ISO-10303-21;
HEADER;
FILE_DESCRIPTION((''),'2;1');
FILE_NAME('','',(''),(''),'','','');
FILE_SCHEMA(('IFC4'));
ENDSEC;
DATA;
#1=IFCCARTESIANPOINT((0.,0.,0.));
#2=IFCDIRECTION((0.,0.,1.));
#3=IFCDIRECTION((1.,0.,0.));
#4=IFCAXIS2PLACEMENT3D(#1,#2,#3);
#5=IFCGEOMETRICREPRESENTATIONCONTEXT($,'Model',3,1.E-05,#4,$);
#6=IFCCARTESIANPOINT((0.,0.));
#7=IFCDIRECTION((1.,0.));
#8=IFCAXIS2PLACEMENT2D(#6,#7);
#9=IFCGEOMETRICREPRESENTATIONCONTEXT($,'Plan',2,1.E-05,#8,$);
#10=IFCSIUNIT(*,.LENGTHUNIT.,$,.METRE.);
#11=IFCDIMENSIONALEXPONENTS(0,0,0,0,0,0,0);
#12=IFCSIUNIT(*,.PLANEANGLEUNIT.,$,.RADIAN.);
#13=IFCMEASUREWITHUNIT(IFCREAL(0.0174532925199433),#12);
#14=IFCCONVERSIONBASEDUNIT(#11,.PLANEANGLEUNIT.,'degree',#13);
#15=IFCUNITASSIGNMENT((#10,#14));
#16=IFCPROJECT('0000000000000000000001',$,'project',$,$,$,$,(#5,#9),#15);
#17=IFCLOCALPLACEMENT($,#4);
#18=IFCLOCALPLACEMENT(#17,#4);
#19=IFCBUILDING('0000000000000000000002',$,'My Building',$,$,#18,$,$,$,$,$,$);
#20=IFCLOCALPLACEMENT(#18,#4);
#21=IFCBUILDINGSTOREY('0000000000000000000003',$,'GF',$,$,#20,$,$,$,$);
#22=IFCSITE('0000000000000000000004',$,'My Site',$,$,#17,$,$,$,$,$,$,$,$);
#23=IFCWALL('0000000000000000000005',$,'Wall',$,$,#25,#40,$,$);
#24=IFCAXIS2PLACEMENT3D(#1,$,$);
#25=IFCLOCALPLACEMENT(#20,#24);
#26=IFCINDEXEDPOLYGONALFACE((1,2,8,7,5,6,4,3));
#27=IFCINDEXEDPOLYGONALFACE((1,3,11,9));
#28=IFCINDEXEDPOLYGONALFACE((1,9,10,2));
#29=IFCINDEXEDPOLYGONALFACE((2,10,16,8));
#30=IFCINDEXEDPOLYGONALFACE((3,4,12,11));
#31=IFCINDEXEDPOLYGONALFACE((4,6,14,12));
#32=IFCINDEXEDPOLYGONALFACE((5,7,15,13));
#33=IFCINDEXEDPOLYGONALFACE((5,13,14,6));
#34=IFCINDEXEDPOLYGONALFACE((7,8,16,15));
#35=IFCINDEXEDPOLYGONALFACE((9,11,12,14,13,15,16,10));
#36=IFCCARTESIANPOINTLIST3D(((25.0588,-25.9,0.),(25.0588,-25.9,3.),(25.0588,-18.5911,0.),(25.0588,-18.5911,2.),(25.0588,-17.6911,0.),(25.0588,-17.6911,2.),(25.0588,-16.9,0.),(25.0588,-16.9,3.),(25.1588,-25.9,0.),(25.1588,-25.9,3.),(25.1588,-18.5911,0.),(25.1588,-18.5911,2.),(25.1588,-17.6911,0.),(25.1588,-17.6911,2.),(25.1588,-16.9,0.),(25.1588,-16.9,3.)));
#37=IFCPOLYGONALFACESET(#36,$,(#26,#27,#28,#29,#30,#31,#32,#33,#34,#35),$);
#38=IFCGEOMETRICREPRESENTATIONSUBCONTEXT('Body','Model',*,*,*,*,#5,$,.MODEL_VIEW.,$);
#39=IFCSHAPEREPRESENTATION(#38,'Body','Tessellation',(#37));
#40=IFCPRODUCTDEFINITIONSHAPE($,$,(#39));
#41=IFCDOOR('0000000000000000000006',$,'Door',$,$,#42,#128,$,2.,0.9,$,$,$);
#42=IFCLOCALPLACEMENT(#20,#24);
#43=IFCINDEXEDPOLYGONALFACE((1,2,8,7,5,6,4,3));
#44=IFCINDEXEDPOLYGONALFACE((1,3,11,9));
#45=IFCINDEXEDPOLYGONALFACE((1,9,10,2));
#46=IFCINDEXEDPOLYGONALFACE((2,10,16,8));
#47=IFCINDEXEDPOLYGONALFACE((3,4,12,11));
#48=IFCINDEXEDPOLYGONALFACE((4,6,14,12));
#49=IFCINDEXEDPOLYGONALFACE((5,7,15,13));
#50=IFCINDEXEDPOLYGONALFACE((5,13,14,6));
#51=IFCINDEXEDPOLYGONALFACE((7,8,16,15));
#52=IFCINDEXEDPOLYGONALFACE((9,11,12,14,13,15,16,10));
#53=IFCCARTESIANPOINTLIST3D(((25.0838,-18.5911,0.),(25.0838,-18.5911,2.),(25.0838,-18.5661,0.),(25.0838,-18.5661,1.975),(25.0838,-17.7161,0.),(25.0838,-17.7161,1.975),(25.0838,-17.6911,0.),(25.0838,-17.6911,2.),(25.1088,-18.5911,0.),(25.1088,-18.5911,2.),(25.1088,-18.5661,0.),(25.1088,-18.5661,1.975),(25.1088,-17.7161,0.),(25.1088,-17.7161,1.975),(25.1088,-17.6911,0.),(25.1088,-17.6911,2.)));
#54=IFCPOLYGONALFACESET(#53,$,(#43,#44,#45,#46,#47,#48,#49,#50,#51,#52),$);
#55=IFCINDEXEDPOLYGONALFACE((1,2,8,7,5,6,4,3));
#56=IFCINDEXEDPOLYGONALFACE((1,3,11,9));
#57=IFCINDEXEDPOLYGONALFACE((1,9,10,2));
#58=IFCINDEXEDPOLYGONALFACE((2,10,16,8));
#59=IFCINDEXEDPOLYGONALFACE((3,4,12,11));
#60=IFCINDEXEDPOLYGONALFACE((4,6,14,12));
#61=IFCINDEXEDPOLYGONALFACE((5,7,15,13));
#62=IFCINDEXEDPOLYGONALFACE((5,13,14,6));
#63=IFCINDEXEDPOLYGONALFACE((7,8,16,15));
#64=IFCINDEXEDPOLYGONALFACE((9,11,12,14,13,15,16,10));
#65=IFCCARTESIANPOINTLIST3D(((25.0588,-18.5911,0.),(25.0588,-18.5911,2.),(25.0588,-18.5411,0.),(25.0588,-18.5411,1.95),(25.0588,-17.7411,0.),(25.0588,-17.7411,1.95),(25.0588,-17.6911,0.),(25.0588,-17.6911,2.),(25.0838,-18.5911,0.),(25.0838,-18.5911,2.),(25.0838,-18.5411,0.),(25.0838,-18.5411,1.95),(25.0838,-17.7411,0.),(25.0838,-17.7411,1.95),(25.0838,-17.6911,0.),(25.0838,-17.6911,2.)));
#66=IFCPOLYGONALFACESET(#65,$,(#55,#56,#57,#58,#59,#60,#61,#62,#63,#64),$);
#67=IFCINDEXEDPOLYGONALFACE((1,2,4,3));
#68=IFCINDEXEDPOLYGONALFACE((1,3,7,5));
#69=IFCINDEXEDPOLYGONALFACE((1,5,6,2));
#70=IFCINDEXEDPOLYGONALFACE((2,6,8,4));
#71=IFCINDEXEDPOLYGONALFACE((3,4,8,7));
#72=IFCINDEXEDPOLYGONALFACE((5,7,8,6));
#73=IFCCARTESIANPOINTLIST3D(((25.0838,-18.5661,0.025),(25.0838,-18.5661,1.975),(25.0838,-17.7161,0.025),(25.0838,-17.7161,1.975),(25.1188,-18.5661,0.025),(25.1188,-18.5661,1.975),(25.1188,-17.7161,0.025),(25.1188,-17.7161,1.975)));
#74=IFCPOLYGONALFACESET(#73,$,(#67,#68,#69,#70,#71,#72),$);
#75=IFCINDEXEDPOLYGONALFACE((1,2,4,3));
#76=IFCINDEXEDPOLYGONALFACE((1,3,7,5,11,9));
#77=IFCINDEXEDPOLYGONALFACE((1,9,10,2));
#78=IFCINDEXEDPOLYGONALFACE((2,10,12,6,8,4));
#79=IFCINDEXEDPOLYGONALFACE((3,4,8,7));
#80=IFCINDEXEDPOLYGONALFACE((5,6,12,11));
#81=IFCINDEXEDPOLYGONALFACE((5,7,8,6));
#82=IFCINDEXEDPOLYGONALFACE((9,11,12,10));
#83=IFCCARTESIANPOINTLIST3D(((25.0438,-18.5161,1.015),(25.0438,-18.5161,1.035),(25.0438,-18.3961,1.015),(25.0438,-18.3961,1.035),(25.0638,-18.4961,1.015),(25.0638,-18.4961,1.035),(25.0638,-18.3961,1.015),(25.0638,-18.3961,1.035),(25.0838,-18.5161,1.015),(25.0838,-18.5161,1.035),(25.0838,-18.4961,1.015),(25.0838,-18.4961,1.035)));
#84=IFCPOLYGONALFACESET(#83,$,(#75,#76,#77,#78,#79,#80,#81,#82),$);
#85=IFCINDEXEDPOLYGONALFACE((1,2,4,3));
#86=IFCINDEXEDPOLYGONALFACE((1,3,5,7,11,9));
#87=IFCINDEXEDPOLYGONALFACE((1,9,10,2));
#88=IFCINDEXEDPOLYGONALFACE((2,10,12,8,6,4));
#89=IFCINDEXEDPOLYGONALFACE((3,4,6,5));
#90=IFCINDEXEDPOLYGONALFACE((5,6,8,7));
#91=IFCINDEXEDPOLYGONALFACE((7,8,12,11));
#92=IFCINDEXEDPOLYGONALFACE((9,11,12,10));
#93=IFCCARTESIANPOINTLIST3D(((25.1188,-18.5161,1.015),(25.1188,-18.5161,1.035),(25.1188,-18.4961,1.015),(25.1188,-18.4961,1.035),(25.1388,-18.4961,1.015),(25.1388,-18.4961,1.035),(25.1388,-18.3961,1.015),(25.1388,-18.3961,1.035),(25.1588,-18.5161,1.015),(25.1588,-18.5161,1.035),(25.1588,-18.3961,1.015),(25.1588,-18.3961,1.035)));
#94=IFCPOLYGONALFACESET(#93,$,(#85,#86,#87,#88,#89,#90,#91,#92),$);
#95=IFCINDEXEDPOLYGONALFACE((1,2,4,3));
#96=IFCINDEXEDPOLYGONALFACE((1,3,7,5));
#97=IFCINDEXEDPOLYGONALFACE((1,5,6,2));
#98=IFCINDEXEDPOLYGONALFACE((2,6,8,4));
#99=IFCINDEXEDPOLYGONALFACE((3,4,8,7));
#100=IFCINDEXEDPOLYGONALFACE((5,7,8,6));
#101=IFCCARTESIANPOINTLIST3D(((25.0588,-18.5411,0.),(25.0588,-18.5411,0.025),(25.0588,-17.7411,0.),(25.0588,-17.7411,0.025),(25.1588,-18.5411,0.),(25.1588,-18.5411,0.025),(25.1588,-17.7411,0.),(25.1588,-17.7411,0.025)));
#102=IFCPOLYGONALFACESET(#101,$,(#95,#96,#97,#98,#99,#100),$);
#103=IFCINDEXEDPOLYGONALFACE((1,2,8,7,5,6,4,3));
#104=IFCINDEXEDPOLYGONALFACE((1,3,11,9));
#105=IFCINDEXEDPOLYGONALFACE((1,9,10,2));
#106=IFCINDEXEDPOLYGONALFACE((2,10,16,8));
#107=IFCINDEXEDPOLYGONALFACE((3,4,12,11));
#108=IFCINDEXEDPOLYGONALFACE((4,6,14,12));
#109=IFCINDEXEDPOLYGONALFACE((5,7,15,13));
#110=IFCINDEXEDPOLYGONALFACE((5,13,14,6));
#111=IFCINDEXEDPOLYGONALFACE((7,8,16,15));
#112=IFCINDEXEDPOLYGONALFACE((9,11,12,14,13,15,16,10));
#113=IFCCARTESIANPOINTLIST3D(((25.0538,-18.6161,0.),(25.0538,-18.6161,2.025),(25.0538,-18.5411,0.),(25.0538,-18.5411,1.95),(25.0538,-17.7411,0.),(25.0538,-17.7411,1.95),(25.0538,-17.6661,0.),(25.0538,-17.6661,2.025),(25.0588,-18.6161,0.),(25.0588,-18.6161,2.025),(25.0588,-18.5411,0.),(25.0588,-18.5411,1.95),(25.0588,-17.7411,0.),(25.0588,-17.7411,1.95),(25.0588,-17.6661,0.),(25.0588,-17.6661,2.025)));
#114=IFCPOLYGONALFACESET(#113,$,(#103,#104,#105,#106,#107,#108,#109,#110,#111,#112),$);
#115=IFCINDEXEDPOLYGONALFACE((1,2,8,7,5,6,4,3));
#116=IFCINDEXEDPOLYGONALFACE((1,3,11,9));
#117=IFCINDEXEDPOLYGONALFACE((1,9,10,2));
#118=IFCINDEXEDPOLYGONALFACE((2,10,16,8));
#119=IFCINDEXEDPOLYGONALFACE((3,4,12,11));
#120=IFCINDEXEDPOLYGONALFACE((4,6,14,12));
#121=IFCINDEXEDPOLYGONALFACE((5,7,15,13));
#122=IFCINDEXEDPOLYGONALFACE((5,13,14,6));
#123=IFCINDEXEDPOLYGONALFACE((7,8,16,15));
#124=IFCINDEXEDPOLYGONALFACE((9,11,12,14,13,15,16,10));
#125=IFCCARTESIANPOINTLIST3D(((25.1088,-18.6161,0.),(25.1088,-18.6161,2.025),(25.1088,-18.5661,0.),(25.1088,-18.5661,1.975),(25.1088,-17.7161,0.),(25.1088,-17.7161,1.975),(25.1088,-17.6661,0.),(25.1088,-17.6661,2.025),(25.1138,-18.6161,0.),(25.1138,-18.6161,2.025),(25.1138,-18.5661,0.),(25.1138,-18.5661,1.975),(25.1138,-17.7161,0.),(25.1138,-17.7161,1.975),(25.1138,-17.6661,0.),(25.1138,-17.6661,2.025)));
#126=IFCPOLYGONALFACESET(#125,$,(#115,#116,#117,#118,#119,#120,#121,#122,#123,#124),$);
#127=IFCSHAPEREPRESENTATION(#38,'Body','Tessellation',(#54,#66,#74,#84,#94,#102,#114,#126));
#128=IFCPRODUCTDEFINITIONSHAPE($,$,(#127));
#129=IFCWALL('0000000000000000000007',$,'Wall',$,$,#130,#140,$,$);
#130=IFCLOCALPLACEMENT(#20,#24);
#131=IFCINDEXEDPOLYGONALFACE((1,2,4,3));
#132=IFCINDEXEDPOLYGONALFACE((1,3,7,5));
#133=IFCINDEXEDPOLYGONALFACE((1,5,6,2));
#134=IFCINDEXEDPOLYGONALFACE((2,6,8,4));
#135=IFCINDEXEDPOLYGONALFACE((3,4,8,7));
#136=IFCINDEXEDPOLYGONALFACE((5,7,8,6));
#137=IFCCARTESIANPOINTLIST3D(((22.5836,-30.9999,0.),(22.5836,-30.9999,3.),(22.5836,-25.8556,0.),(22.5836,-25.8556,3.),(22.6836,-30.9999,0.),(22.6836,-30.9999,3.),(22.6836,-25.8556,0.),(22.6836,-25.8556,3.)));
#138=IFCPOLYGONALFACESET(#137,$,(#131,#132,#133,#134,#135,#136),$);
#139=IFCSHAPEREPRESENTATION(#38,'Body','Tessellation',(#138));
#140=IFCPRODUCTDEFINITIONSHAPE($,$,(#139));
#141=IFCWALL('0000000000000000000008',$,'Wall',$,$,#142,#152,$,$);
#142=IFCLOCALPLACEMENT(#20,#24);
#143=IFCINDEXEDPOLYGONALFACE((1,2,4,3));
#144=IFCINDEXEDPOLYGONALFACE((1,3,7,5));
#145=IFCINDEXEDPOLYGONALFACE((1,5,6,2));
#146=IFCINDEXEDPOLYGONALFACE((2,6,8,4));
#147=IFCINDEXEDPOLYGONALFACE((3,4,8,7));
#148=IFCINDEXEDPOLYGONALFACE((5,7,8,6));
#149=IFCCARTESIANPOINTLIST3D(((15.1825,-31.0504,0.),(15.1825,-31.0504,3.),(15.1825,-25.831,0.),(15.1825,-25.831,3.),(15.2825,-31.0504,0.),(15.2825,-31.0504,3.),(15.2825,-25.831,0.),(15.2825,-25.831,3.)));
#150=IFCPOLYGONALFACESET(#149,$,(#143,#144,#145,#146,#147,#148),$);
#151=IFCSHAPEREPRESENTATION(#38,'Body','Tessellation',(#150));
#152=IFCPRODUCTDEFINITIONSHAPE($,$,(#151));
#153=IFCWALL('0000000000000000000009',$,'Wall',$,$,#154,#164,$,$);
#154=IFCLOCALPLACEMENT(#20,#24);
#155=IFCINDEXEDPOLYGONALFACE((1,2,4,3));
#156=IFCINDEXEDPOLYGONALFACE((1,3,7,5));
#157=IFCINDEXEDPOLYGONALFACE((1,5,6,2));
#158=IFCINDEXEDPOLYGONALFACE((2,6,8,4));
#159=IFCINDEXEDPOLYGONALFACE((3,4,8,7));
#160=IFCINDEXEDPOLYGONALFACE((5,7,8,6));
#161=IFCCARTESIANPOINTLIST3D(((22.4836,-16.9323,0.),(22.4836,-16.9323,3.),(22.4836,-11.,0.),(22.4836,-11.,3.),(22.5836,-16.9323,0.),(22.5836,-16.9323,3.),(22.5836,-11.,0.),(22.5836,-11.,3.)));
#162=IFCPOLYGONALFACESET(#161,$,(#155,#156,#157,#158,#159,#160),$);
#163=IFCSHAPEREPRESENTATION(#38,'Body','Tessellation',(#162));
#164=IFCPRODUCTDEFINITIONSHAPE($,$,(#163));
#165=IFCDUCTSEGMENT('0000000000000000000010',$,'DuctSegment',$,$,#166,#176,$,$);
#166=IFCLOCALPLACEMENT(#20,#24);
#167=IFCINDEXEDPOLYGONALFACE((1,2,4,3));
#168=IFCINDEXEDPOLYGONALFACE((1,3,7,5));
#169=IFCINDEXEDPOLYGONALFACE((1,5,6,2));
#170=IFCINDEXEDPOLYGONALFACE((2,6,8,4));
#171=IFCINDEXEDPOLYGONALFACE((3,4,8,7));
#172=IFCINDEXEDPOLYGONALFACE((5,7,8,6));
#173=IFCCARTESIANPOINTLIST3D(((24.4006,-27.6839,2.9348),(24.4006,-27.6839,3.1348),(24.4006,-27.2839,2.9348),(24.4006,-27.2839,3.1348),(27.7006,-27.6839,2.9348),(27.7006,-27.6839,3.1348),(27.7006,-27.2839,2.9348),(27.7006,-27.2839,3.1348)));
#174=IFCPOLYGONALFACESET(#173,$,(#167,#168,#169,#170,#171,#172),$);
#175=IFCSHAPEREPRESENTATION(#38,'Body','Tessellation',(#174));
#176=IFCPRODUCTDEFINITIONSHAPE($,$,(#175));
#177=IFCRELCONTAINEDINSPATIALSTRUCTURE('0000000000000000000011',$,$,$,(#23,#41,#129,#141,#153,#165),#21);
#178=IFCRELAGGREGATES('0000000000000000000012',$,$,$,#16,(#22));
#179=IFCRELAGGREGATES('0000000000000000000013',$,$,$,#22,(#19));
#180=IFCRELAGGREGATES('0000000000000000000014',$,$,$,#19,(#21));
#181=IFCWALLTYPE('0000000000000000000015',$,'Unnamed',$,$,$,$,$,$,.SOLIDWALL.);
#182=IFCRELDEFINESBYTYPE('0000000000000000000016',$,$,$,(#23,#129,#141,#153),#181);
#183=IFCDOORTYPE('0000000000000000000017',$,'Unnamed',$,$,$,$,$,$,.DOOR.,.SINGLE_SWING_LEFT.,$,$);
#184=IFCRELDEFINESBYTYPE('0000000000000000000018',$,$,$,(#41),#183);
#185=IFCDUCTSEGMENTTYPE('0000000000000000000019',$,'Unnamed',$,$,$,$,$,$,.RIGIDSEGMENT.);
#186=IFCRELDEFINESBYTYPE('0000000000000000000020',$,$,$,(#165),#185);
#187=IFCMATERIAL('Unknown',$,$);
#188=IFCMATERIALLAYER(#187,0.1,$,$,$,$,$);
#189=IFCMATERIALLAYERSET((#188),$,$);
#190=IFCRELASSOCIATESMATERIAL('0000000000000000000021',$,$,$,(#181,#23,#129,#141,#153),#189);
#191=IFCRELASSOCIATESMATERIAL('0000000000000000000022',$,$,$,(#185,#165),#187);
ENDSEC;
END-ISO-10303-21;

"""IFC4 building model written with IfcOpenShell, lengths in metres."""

from ifc_helpers import new_model, entity, si_unit, converted_unit, frame, origin_with_axes, origin_2d_with_axis, place, context, subcontext, project, spatial, line, indexed_curve, rectangle, outline, extrude, shape, source, transform, mapped, material, layer, layer_set, layer_usage, material_profile, profile_set, profile_usage, type_object, type_shapes, element, fill, save


model = new_model("IFC4")

# Units and contexts
model_context = context("Model", 3, precision=1e-05, world=origin_with_axes())
plan_context = context("Plan", 2, precision=1e-05, world=origin_2d_with_axis())
body_context_1 = subcontext(model_context, "Body", "Model", "MODEL_VIEW")
body_context_2 = subcontext(plan_context, "Body", "Plan", "PLAN_VIEW")
ifc_project = project(units=[si_unit("LENGTHUNIT", "METRE"), converted_unit("PLANEANGLEUNIT", "degree", entity("IfcReal", 0.0174532925199433), si_unit("PLANEANGLEUNIT", "RADIAN"), dimensions=[0, 0, 0, 0, 0, 0, 0])], contexts=[model_context, plan_context])

# Site, building, storey
site_placement = place(None, origin_with_axes())
site = spatial("IfcSite", under=ifc_project, at=site_placement, Name="My Site")
building_placement = place(site_placement, origin_with_axes())
building = spatial("IfcBuilding", under=site, at=building_placement, Name="My Building")
storey_placement = place(building_placement, origin_with_axes())
storey = spatial("IfcBuildingStorey", under=building, at=storey_placement, Name="GF")

# Shared definitions
ifc_material = material(Name="Unknown")
ifc_layer = layer(ifc_material, 0.1)
ifc_layer_set = layer_set([ifc_layer])
wall_type = type_object("IfcWallType", Name="Unnamed", PredefinedType="SOLIDWALL", material=ifc_layer_set)

# Shared definitions
shared_shape_1 = source(origin_with_axes(), body_context_1, "Body", "SweptSolid", [
    extrude(outline(indexed_curve([(0.0, 0.0), (0.9, 0.0), (0.9, 2.0), (0.0, 2.0)], segments=[line(1, 2, 3, 4, 1)])), frame((0.0, -0.6, 0.0), z_axis=(0.0, -1.0, 0.0), x_axis=(1.0, 0.0, 0.0)), (0.0, 0.0, -1.0), 1.2),
])
door_type = type_object("IfcDoorType", Name="Unnamed", OperationType="SINGLE_SWING_LEFT", PredefinedType="DOOR")
shared_shape_2 = source(origin_with_axes(), body_context_1, "Body", "SweptSolid", [
    extrude(outline(indexed_curve([(0.0, 0.0), (0.0, 2.0), (0.9, 2.0), (0.9, 0.0), (0.875, 0.0), (0.875, 1.975), (0.025, 1.975), (0.025, 0.0)], segments=[line(1, 2, 3, 4, 5, 6, 7, 8, 1)])), frame((0.0, 0.025, 0.0), z_axis=(0.0, -1.0, 0.0), x_axis=(1.0, 0.0, 0.0)), (0.0, 0.0, -1.0), 0.025),
    extrude(outline(indexed_curve([(0.0, 0.0), (0.0, 2.0), (0.9, 2.0), (0.9, 0.0), (0.85, 0.0), (0.85, 1.95), (0.05, 1.95), (0.05, 0.0)], segments=[line(1, 2, 3, 4, 5, 6, 7, 8, 1)])), frame((0.0, 0.0, 0.0), z_axis=(0.0, -1.0, 0.0), x_axis=(1.0, 0.0, 0.0)), (0.0, 0.0, -1.0), 0.025),
    extrude(outline(indexed_curve([(0.0, 0.0), (0.85, 0.0), (0.85, 0.035), (0.0, 0.035)], segments=[line(1, 2, 3, 4, 1)])), frame((0.025, 0.025, 0.025), z_axis=(0.0, 0.0, 1.0), x_axis=(1.0, 0.0, 0.0)), (0.0, 0.0, 1.0), 1.95),
    extrude(outline(indexed_curve([(0.0, 0.0), (0.0, -0.04), (-0.12, -0.04), (-0.12, -0.02), (-0.02, -0.02), (-0.02, 0.0)], segments=[line(1, 2, 3, 4, 5, 6, 1)])), frame((0.825, 0.025, 1.015), z_axis=(0.0, 0.0, 1.0), x_axis=(1.0, 0.0, 0.0)), (0.0, 0.0, 1.0), 0.02),
    extrude(outline(indexed_curve([(0.0, 0.0), (0.0, 0.04), (-0.12, 0.04), (-0.12, 0.02), (-0.02, 0.02), (-0.02, 0.0)], segments=[line(1, 2, 3, 4, 5, 6, 1)])), frame((0.825, 0.06, 1.015), z_axis=(0.0, 0.0, 1.0), x_axis=(1.0, 0.0, 0.0)), (0.0, 0.0, 1.0), 0.02),
    extrude(outline(indexed_curve([(0.0, 0.0), (0.8, 0.0), (0.8, 0.1), (0.0, 0.1)], segments=[line(1, 2, 3, 4, 1)])), frame((0.05, 0.0, 0.0), z_axis=(0.0, 0.0, 1.0), x_axis=(1.0, 0.0, 0.0)), (0.0, 0.0, 1.0), 0.025),
    extrude(outline(indexed_curve([(0.0, 0.0), (0.0, 2.025), (0.95, 2.025), (0.95, 0.0), (0.875, 0.0), (0.875, 1.95), (0.075, 1.95), (0.075, 0.0)], segments=[line(1, 2, 3, 4, 5, 6, 7, 8, 1)])), frame((-0.025, -0.005, 0.0), z_axis=(0.0, -1.0, 0.0), x_axis=(1.0, 0.0, 0.0)), (0.0, 0.0, -1.0), 0.005),
    extrude(outline(indexed_curve([(0.0, 0.0), (0.0, 2.025), (0.95, 2.025), (0.95, 0.0), (0.9, 0.0), (0.9, 1.975), (0.05, 1.975), (0.05, 0.0)], segments=[line(1, 2, 3, 4, 5, 6, 7, 8, 1)])), frame((-0.025, 0.05, 0.0), z_axis=(0.0, -1.0, 0.0), x_axis=(1.0, 0.0, 0.0)), (0.0, 0.0, -1.0), 0.005),
])
shared_shape_3 = source(origin_with_axes(), body_context_2, "Body", "Curve2D", [
    entity("IfcIndexedPolyCurve", entity("IfcCartesianPointList2D", [[0.0, 0.0], [0.0, 0.05], [0.025, 0.05], [0.025, 0.025], [0.05, 0.025], [0.05, 0.0]]), [entity("IfcLineIndex", [1, 2, 3, 4, 5, 6, 1])]),
    entity("IfcIndexedPolyCurve", entity("IfcCartesianPointList2D", [[0.9, 0.0], [0.9, 0.05], [0.875, 0.05], [0.875, 0.025], [0.85, 0.025], [0.85, 0.0]]), [entity("IfcLineIndex", [1, 2, 3, 4, 5, 6, 1])]),
    entity("IfcTrimmedCurve", entity("IfcEllipse", entity("IfcAxis2Placement2D", entity("IfcCartesianPoint", [0.06, 0.05]), entity("IfcDirection", [1.0, 0.0])), 0.815, 0.85), [entity("IfcCartesianPoint", [0.875, 0.05])], [entity("IfcCartesianPoint", [0.06, 0.9])], True, "CARTESIAN"),
    entity("IfcIndexedPolyCurve", entity("IfcCartesianPointList2D", [[0.025, 0.05], [0.06, 0.05], [0.06, 0.9], [0.025, 0.9]]), [entity("IfcLineIndex", [1, 2, 3, 4, 1])]),
])
type_shapes(door_type, [shared_shape_2, shared_shape_3])

# Wall, opening, door
ifc_layer_usage_1 = layer_usage(ifc_layer_set, "AXIS2", "POSITIVE", 0.0)
wall_1_placement = place(storey_placement, frame((25.0588, -16.9, 0.0), z_axis=(0.0, 0.0, 1.0), x_axis=(0.0, -1.0, 0.0)))
wall_1 = element("IfcWall", 1, at=wall_1_placement, inside=storey, type_object=wall_type, material=ifc_layer_usage_1, Name="Wall", context=body_context_1, shape_type="SweptSolid", body=[
    extrude(outline(indexed_curve([(0.0, 0.0), (0.0, 0.1), (9.0, 0.1), (9.0, 0.0)], segments=[line(1, 2, 3, 4, 1)])), origin_with_axes(), (0.0, 0.0, 1.0), 3.0),
])
opening_1_placement = place(wall_1_placement, frame((0.7911, 0.0, 0.0), z_axis=(0.0, 0.0, 1.0), x_axis=(1.0, 0.0, 0.0)))
opening_1 = element("IfcOpeningElement", 2, at=opening_1_placement, cuts=wall_1, PredefinedType="OPENING", context=body_context_1, shape_type="MappedRepresentation", body=[
    mapped(shared_shape_1, transform((0.0, 0.0, 0.0), x_axis=(1.0, 0.0, 0.0), y_axis=(0.0, 1.0, 0.0), z_axis=(0.0, 0.0, 1.0), scale=1.0)),
])
door_1_placement = place(opening_1_placement, frame((0.0, 0.0, 0.0), z_axis=(0.0, 0.0, 1.0), x_axis=(1.0, 0.0, 0.0)))
door_1 = element("IfcDoor", 3, at=door_1_placement, inside=storey, type_object=door_type, Name="Door", OverallHeight=2.0, OverallWidth=0.9, shapes=[
    shape(body_context_1, "Body", "MappedRepresentation", [mapped(shared_shape_2, transform((0.0, 0.0, 0.0), x_axis=(1.0, 0.0, 0.0), y_axis=(0.0, 1.0, 0.0), z_axis=(0.0, 0.0, 1.0), scale=1.0))]),
    shape(body_context_2, "Body", "MappedRepresentation", [mapped(shared_shape_3, transform((0.0, 0.0, 0.0), x_axis=(1.0, 0.0, 0.0), y_axis=(0.0, 1.0, 0.0), z_axis=(0.0, 0.0, 1.0), scale=1.0))]),
])
fill(opening_1, door_1)

# Walls
ifc_layer_usage_2 = layer_usage(ifc_layer_set, "AXIS2", "POSITIVE", 0.0)
wall_2_placement = place(storey_placement, frame((22.5836, -25.8556, 0.0), z_axis=(0.0, 0.0, 1.0), x_axis=(0.0, -1.0, 0.0)))
element("IfcWall", 4, at=wall_2_placement, inside=storey, type_object=wall_type, material=ifc_layer_usage_2, Name="Wall", context=body_context_1, shape_type="SweptSolid", body=[
    extrude(outline(indexed_curve([(0.0, 0.0), (0.0, 0.1), (5.1443, 0.1), (5.1443, 0.0)], segments=[line(1, 2, 3, 4, 1)])), origin_with_axes(), (0.0, 0.0, 1.0), 3.0),
])
ifc_layer_usage_3 = layer_usage(ifc_layer_set, "AXIS2", "POSITIVE", 0.0)
wall_3_placement = place(storey_placement, frame((15.1825, -25.831, 0.0), z_axis=(0.0, 0.0, 1.0), x_axis=(0.0, -1.0, 0.0)))
element("IfcWall", 5, at=wall_3_placement, inside=storey, type_object=wall_type, material=ifc_layer_usage_3, Name="Wall", context=body_context_1, shape_type="SweptSolid", body=[
    extrude(outline(indexed_curve([(0.0, 0.0), (0.0, 0.1), (5.2194, 0.1), (5.2194, 0.0)], segments=[line(1, 2, 3, 4, 1)])), origin_with_axes(), (0.0, 0.0, 1.0), 3.0),
])
ifc_layer_usage_4 = layer_usage(ifc_layer_set, "AXIS2", "POSITIVE", 0.0)
wall_4_placement = place(storey_placement, frame((22.5836, -16.9323, 0.0), z_axis=(0.0, 0.0, 1.0), x_axis=(0.0, 1.0, 0.0)))
element("IfcWall", 6, at=wall_4_placement, inside=storey, type_object=wall_type, material=ifc_layer_usage_4, Name="Wall", context=body_context_1, shape_type="SweptSolid", body=[
    extrude(outline(indexed_curve([(0.0, 0.0), (0.0, 0.1), (5.9323, 0.1), (5.9323, 0.0)], segments=[line(1, 2, 3, 4, 1)])), origin_with_axes(), (0.0, 0.0, 1.0), 3.0),
])

# Duct segment
ifc_material_profile_1 = material_profile(ifc_material, rectangle(XDim=0.4, YDim=0.2))
ifc_profile_set_1 = profile_set([ifc_material_profile_1])
ifc_profile_usage_1 = profile_usage(ifc_profile_set_1, cardinal=5)
duct_segment_type = type_object("IfcDuctSegmentType", Name="Unnamed", PredefinedType="RIGIDSEGMENT", material=ifc_profile_set_1)
duct_segment_1_placement = place(storey_placement, frame((24.4006, -27.4839, 3.0348), z_axis=(1.0, 0.0, 0.0), x_axis=(0.0, 1.0, 0.0)))
element("IfcDuctSegment", 7, at=duct_segment_1_placement, inside=storey, type_object=duct_segment_type, material=ifc_profile_usage_1, Name="DuctSegment", context=body_context_1, shape_type="SweptSolid", body=[
    extrude(rectangle(XDim=0.4, YDim=0.2), origin_with_axes(), (0.0, 0.0, 1.0), 3.3),
])

save(model, "model.ifc")
